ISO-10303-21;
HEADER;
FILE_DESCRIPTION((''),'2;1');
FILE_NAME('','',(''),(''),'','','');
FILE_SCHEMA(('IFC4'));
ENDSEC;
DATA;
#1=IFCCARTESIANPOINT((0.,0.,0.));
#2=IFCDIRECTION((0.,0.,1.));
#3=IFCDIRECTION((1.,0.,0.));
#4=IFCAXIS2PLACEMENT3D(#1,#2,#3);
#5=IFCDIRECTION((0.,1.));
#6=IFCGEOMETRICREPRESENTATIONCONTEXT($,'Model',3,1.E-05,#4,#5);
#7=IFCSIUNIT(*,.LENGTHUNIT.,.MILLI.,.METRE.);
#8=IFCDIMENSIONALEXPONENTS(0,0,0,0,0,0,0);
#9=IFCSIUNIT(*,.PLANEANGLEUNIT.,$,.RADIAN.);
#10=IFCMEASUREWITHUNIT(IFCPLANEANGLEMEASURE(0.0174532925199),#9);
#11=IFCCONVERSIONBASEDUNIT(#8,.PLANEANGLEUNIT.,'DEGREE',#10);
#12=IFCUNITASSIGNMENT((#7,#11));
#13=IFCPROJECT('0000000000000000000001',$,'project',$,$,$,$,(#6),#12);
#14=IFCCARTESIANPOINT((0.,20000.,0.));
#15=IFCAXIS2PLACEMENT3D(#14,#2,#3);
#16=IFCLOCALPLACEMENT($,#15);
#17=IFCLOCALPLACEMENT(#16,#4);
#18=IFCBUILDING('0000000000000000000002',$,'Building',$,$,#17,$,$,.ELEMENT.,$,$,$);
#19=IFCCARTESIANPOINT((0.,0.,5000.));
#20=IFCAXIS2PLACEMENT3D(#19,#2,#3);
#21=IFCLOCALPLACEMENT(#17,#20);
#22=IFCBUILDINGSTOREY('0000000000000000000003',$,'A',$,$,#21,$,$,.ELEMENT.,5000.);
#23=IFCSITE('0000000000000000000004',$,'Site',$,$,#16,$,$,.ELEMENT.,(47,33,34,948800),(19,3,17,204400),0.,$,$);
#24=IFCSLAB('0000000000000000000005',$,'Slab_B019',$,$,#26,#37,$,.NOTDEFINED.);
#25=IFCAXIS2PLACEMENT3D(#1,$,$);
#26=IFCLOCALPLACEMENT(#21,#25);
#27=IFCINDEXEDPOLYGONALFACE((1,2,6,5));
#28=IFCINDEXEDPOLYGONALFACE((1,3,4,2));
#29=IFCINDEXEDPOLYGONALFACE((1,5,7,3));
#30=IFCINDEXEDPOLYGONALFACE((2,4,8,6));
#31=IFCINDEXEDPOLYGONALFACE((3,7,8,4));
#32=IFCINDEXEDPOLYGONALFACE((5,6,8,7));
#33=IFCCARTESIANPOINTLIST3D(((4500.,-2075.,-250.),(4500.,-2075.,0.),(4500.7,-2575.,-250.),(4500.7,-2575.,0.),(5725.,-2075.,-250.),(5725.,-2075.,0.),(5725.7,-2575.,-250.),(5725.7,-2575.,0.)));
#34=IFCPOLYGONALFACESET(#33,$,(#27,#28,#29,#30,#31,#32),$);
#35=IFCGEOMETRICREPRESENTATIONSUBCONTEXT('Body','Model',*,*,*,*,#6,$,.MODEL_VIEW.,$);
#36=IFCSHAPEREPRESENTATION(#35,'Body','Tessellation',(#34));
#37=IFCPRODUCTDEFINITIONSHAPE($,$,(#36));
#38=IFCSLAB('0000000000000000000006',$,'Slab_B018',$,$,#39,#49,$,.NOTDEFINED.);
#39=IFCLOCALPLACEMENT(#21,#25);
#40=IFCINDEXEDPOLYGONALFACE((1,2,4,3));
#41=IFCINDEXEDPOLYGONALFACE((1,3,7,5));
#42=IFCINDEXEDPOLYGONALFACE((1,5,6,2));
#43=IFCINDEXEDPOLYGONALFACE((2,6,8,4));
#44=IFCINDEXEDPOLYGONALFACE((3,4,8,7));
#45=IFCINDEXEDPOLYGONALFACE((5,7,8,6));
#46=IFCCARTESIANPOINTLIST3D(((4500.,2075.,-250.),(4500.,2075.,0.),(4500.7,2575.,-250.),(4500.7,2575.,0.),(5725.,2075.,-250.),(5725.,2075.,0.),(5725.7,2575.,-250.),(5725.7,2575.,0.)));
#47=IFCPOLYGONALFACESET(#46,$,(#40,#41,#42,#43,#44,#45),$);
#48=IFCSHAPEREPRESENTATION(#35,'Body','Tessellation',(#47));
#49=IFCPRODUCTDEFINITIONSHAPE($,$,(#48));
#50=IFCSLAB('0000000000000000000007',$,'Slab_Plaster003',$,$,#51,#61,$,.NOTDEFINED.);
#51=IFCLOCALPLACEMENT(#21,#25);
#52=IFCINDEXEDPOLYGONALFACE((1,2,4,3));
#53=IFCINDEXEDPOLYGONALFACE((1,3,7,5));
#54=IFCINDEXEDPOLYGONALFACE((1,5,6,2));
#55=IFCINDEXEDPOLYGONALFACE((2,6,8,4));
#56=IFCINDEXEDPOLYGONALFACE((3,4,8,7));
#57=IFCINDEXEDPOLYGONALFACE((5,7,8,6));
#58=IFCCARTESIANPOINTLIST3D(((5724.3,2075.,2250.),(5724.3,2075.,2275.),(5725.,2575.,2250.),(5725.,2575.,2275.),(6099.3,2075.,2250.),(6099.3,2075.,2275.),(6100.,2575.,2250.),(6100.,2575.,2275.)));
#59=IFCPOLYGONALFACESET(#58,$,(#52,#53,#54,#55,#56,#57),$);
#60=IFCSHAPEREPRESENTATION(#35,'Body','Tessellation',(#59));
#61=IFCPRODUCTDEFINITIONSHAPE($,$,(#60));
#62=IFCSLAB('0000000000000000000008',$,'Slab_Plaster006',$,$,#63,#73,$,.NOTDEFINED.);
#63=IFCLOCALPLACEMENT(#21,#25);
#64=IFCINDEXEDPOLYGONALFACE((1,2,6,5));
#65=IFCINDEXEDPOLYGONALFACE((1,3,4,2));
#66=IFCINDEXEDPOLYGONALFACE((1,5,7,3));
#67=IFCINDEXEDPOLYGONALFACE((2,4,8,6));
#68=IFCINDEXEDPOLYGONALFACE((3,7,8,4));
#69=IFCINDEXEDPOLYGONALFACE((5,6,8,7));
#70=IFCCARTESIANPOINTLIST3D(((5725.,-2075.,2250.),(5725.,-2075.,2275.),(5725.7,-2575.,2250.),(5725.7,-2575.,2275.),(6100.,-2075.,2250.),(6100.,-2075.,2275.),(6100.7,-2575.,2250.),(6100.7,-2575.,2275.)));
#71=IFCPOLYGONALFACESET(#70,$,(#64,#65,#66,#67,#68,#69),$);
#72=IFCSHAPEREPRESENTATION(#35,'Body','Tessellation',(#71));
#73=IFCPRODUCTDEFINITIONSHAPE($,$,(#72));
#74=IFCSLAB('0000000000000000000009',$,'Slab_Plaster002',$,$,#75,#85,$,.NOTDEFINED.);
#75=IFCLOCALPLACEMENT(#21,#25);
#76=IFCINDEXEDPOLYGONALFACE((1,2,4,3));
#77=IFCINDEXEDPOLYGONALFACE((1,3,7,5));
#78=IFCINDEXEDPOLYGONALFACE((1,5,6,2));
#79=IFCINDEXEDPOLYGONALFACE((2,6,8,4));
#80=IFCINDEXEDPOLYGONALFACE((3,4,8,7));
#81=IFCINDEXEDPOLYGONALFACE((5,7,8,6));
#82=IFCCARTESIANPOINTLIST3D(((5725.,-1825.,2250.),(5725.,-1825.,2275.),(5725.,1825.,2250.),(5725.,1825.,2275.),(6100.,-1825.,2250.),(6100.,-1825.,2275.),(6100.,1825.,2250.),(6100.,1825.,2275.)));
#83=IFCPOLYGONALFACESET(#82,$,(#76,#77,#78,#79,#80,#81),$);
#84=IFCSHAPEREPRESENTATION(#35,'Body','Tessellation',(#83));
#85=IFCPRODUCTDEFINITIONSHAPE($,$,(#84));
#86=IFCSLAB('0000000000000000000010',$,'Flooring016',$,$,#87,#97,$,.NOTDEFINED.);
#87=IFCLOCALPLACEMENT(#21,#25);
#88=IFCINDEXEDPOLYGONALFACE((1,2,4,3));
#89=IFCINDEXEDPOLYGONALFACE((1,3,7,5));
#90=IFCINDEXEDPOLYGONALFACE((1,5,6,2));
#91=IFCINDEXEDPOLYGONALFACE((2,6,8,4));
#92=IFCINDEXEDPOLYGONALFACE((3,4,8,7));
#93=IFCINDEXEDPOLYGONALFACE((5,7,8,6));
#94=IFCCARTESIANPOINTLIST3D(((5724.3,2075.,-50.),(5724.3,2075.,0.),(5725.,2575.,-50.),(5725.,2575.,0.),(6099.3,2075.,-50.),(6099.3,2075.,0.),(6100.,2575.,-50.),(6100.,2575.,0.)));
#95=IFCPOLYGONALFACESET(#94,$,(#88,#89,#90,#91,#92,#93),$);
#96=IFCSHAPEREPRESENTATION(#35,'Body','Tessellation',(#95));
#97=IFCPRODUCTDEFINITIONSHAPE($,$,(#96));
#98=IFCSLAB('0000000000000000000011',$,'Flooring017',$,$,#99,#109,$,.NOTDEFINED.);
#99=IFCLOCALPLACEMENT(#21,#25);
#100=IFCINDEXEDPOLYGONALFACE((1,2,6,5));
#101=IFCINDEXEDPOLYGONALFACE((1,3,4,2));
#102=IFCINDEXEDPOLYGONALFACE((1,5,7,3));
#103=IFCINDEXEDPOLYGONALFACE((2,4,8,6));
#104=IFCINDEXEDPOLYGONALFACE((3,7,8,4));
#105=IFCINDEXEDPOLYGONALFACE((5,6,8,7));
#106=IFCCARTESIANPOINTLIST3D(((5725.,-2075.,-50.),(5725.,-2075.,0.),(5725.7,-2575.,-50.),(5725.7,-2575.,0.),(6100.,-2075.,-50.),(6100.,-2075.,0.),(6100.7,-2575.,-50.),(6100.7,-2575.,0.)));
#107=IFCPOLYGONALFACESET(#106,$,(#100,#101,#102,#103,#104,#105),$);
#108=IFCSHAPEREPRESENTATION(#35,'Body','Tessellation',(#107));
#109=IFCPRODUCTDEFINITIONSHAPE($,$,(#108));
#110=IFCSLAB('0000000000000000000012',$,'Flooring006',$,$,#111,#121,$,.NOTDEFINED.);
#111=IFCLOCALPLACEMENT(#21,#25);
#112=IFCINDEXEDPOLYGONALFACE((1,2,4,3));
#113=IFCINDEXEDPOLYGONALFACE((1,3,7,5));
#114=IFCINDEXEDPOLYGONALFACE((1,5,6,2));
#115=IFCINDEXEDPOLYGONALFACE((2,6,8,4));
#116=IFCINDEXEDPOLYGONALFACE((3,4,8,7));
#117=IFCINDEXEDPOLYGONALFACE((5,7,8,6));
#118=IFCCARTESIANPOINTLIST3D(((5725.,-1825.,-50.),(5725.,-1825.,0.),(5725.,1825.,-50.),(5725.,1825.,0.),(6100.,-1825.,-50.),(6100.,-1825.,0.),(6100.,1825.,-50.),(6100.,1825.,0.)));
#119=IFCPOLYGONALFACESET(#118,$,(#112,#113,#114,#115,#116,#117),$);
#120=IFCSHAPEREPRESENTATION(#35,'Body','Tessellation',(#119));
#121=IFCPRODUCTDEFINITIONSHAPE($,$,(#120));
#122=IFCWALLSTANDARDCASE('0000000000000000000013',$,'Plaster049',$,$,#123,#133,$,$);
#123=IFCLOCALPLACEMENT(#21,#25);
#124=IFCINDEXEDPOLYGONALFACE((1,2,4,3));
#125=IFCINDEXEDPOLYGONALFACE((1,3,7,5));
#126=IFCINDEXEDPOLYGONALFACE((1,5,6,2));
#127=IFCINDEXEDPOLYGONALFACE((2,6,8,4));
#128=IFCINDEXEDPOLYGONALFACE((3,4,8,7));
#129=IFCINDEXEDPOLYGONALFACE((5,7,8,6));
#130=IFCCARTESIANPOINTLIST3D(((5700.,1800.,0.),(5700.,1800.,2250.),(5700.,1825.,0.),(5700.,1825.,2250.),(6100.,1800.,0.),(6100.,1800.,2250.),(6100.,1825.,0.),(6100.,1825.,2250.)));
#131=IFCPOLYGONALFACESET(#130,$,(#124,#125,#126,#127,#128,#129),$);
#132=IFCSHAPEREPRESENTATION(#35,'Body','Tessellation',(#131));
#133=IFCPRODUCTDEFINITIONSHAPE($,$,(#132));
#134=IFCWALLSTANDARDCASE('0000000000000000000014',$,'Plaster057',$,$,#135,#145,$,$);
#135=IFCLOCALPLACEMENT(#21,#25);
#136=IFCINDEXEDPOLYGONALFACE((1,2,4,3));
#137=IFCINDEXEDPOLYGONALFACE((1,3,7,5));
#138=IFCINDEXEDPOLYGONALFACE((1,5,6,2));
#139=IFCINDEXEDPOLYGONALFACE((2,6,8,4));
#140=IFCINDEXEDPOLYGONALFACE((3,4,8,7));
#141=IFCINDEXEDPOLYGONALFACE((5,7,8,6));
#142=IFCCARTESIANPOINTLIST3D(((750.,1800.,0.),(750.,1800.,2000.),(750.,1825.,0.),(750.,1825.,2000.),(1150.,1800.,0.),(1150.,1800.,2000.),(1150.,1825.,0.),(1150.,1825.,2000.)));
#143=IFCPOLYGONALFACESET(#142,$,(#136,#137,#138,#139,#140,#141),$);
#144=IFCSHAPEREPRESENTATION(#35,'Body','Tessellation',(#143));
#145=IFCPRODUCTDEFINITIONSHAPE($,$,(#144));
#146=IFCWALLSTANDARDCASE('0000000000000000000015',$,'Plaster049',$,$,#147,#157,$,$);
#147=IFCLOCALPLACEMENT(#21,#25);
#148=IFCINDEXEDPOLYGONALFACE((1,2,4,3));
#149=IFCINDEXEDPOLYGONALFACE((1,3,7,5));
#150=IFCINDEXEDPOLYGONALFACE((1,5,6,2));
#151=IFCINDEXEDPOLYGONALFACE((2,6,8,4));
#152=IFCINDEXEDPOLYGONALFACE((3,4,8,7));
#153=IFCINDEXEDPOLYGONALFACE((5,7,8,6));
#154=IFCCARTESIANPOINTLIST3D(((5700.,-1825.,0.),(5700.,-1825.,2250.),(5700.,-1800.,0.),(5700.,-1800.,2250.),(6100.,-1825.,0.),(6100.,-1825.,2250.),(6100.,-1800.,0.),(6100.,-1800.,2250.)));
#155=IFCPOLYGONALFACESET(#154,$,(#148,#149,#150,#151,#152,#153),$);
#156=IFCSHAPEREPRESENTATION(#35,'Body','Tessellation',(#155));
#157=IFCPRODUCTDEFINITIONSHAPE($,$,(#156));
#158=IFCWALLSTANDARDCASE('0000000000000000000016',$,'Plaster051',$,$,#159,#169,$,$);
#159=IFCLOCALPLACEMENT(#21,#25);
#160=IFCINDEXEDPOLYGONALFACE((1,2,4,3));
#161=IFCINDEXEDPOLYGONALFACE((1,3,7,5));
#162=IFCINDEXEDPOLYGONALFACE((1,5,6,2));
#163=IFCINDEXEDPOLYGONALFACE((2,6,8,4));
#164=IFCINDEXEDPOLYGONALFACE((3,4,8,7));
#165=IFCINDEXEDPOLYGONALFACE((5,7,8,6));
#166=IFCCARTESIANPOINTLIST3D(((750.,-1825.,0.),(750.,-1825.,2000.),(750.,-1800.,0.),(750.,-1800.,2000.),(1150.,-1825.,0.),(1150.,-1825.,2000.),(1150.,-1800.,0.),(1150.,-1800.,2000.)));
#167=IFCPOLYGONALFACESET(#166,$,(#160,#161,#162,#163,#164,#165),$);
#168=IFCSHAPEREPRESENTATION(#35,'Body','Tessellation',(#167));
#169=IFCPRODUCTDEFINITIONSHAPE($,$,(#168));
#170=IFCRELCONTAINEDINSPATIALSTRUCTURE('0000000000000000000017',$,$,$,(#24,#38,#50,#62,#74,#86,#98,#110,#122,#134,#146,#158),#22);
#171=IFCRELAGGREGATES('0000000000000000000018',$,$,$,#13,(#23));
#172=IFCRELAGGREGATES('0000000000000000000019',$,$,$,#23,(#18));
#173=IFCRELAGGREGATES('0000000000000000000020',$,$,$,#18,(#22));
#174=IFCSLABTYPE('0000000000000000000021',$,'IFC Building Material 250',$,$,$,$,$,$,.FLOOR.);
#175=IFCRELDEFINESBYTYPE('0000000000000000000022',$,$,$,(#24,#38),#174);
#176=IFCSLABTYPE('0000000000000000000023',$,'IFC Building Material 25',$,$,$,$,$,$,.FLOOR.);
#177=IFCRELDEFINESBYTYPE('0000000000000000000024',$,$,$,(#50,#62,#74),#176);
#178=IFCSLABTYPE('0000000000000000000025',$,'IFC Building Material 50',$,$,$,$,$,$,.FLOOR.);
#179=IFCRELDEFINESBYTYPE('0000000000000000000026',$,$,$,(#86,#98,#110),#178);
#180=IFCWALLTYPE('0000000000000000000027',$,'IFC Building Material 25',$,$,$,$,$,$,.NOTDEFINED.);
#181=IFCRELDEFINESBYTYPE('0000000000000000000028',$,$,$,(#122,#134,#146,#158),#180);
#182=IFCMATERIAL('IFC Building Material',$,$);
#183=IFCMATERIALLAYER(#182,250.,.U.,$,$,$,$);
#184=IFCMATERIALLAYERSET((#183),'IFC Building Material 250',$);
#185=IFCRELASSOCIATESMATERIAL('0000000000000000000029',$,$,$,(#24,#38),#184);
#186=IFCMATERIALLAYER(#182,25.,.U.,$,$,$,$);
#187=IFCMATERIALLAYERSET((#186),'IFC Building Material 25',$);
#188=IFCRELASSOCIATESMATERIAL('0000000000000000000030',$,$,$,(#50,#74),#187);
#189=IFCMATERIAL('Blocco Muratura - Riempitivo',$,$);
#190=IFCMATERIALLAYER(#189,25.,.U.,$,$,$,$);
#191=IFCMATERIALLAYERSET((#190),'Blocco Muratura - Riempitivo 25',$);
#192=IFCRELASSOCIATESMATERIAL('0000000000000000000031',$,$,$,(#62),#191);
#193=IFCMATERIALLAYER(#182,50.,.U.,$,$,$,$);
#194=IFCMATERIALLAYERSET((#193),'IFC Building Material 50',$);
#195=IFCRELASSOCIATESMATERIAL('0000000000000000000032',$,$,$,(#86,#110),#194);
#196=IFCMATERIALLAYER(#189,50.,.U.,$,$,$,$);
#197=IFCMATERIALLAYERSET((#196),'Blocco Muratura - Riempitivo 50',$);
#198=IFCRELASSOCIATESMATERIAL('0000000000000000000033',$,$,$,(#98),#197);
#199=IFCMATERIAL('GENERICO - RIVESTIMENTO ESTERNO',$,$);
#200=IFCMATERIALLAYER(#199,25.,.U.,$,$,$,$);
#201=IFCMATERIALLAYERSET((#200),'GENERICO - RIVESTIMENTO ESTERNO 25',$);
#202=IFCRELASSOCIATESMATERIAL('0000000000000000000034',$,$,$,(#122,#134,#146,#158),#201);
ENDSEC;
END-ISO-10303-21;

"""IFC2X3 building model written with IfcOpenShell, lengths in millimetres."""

from ifc_helpers import new_model, entity, si_unit, converted_unit, direction, frame, origin_with_axes, place, context, subcontext, project, spatial, polyline, outline, extrude, material, layer, layer_set, layer_usage, type_object, element, save


model = new_model("IFC2X3")

# Units and contexts
model_context = context("Model", 3, precision=1e-05, world=origin_with_axes(), true_north=direction((0.0, 1.0)))
body_context = subcontext(model_context, "Body", "Model", "MODEL_VIEW")
ifc_project = project(units=[si_unit("LENGTHUNIT", "METRE", prefix="MILLI"), converted_unit("PLANEANGLEUNIT", "DEGREE", entity("IfcPlaneAngleMeasure", 0.0174532925199), si_unit("PLANEANGLEUNIT", "RADIAN"), dimensions=[0, 0, 0, 0, 0, 0, 0])], contexts=[model_context])

# Site, building, storey
site_placement = place(None, frame((0.0, 20000.0, 0.0), z_axis=(0.0, 0.0, 1.0), x_axis=(1.0, 0.0, 0.0)))
site = spatial("IfcSite", under=ifc_project, at=site_placement, Name="Site", CompositionType="ELEMENT", RefLatitude=(47, 33, 34, 948800), RefLongitude=(19, 3, 17, 204400), RefElevation=0.0)
building_placement = place(site_placement, origin_with_axes())
building = spatial("IfcBuilding", under=site, at=building_placement, Name="Building", CompositionType="ELEMENT")
storey_placement = place(building_placement, frame((0.0, 0.0, 5000.0), z_axis=(0.0, 0.0, 1.0), x_axis=(1.0, 0.0, 0.0)))
storey = spatial("IfcBuildingStorey", under=building, at=storey_placement, Name="A", CompositionType="ELEMENT", Elevation=5000.0)

# Shared definitions
ifc_material_1 = material(Name="GENERICO - RIVESTIMENTO ESTERNO")

# Slabs
ifc_material_2 = material(Name="IFC Building Material")
ifc_layer_1 = layer(ifc_material_2, 250.0, ventilated="UNKNOWN")
ifc_layer_set_1 = layer_set([ifc_layer_1], Name="IFC Building Material 250")
slab_type_1 = type_object("IfcSlabType", Name="IFC Building Material 250", PredefinedType="FLOOR")
ifc_layer_usage_1 = layer_usage(ifc_layer_set_1, "AXIS3", "NEGATIVE", 250.0)
slab_1_placement = place(storey_placement, frame((5725.0, -2075.0, 0.0), z_axis=(0.0, 0.0, 1.0), x_axis=(1.0, 0.0, 0.0)))
element("IfcSlab", 1, at=slab_1_placement, inside=storey, type_object=slab_type_1, material=ifc_layer_usage_1, Name="Slab_B019", PredefinedType="NOTDEFINED", context=body_context, shape_type="SweptSolid", body=[
    extrude(outline(polyline([(0.0, 0.0), (-1225.0, 0.0), (-1224.3, -500.0), (0.7, -500.0), (0.0, 0.0)])), frame((0.0, 0.0, -250.0), z_axis=(0.0, 0.0, 1.0), x_axis=(1.0, 0.0, 0.0)), (0.0, 0.0, 1.0), 250.0),
])
ifc_layer_usage_2 = layer_usage(ifc_layer_set_1, "AXIS3", "NEGATIVE", 250.0)
slab_2_placement = place(storey_placement, frame((4500.7, 2575.0, 0.0), z_axis=(0.0, 0.0, 1.0), x_axis=(1.0, 0.0, 0.0)))
element("IfcSlab", 2, at=slab_2_placement, inside=storey, type_object=slab_type_1, material=ifc_layer_usage_2, Name="Slab_B018", PredefinedType="NOTDEFINED", context=body_context, shape_type="SweptSolid", body=[
    extrude(outline(polyline([(0.0, 0.0), (-0.7, -500.0), (1224.3, -500.0), (1225.0, 0.0), (0.0, 0.0)])), frame((0.0, 0.0, -250.0), z_axis=(0.0, 0.0, 1.0), x_axis=(1.0, 0.0, 0.0)), (0.0, 0.0, 1.0), 250.0),
])
ifc_layer_2 = layer(ifc_material_2, 25.0, ventilated="UNKNOWN")
ifc_layer_set_2 = layer_set([ifc_layer_2], Name="IFC Building Material 25")
ifc_layer_usage_3 = layer_usage(ifc_layer_set_2, "AXIS3", "NEGATIVE", 25.0)
slab_type_2 = type_object("IfcSlabType", Name="IFC Building Material 25", PredefinedType="FLOOR")
slab_3_placement = place(storey_placement, frame((5724.3, 2075.0, 2275.0), z_axis=(0.0, 0.0, 1.0), x_axis=(1.0, 0.0, 0.0)))
element("IfcSlab", 3, at=slab_3_placement, inside=storey, type_object=slab_type_2, material=ifc_layer_usage_3, Name="Slab_Plaster003", PredefinedType="NOTDEFINED", context=body_context, shape_type="SweptSolid", body=[
    extrude(outline(polyline([(0.0, 0.0), (375.0, 0.0), (375.7, 500.0), (0.7, 500.0), (0.0, 0.0)])), frame((0.0, 0.0, -25.0), z_axis=(0.0, 0.0, 1.0), x_axis=(1.0, 0.0, 0.0)), (0.0, 0.0, 1.0), 25.0),
])
ifc_material_3 = material(Name="Blocco Muratura - Riempitivo")
ifc_layer_3 = layer(ifc_material_3, 25.0, ventilated="UNKNOWN")
ifc_layer_set_3 = layer_set([ifc_layer_3], Name="Blocco Muratura - Riempitivo 25")
ifc_layer_usage_4 = layer_usage(ifc_layer_set_3, "AXIS3", "NEGATIVE", 25.0)
slab_4_placement = place(storey_placement, frame((5725.0, -2075.0, 2275.0), z_axis=(0.0, 0.0, 1.0), x_axis=(1.0, 0.0, 0.0)))
element("IfcSlab", 4, at=slab_4_placement, inside=storey, type_object=slab_type_2, material=ifc_layer_usage_4, Name="Slab_Plaster006", PredefinedType="NOTDEFINED", context=body_context, shape_type="SweptSolid", body=[
    extrude(outline(polyline([(0.0, 0.0), (0.7, -500.0), (375.7, -500.0), (375.0, 0.0), (0.0, 0.0)])), frame((0.0, 0.0, -25.0), z_axis=(0.0, 0.0, 1.0), x_axis=(1.0, 0.0, 0.0)), (0.0, 0.0, 1.0), 25.0),
])
ifc_layer_usage_5 = layer_usage(ifc_layer_set_2, "AXIS3", "NEGATIVE", 25.0)
slab_5_placement = place(storey_placement, frame((5725.0, 1825.0, 2275.0), z_axis=(0.0, 0.0, 1.0), x_axis=(1.0, 0.0, 0.0)))
element("IfcSlab", 5, at=slab_5_placement, inside=storey, type_object=slab_type_2, material=ifc_layer_usage_5, Name="Slab_Plaster002", PredefinedType="NOTDEFINED", context=body_context, shape_type="SweptSolid", body=[
    extrude(outline(polyline([(0.0, 0.0), (0.0, -3650.0), (375.0, -3650.0), (375.0, 0.0), (0.0, 0.0)])), frame((0.0, 0.0, -25.0), z_axis=(0.0, 0.0, 1.0), x_axis=(1.0, 0.0, 0.0)), (0.0, 0.0, 1.0), 25.0),
])
ifc_layer_4 = layer(ifc_material_2, 50.0, ventilated="UNKNOWN")
ifc_layer_set_4 = layer_set([ifc_layer_4], Name="IFC Building Material 50")
ifc_layer_usage_6 = layer_usage(ifc_layer_set_4, "AXIS3", "NEGATIVE", 50.0)
slab_type_3 = type_object("IfcSlabType", Name="IFC Building Material 50", PredefinedType="FLOOR")
slab_6_placement = place(storey_placement, frame((5724.3, 2075.0, 0.0), z_axis=(0.0, 0.0, 1.0), x_axis=(1.0, 0.0, 0.0)))
element("IfcSlab", 6, at=slab_6_placement, inside=storey, type_object=slab_type_3, material=ifc_layer_usage_6, Name="Flooring016", PredefinedType="NOTDEFINED", context=body_context, shape_type="SweptSolid", body=[
    extrude(outline(polyline([(0.0, 0.0), (375.0, 0.0), (375.7, 500.0), (0.7, 500.0), (0.0, 0.0)])), frame((0.0, 0.0, -50.0), z_axis=(0.0, 0.0, 1.0), x_axis=(1.0, 0.0, 0.0)), (0.0, 0.0, 1.0), 50.0),
])
ifc_layer_5 = layer(ifc_material_3, 50.0, ventilated="UNKNOWN")
ifc_layer_set_5 = layer_set([ifc_layer_5], Name="Blocco Muratura - Riempitivo 50")
ifc_layer_usage_7 = layer_usage(ifc_layer_set_5, "AXIS3", "NEGATIVE", 50.0)
slab_7_placement = place(storey_placement, frame((5725.0, -2075.0, 0.0), z_axis=(0.0, 0.0, 1.0), x_axis=(1.0, 0.0, 0.0)))
element("IfcSlab", 7, at=slab_7_placement, inside=storey, type_object=slab_type_3, material=ifc_layer_usage_7, Name="Flooring017", PredefinedType="NOTDEFINED", context=body_context, shape_type="SweptSolid", body=[
    extrude(outline(polyline([(0.0, 0.0), (0.7, -500.0), (375.7, -500.0), (375.0, 0.0), (0.0, 0.0)])), frame((0.0, 0.0, -50.0), z_axis=(0.0, 0.0, 1.0), x_axis=(1.0, 0.0, 0.0)), (0.0, 0.0, 1.0), 50.0),
])
ifc_layer_usage_8 = layer_usage(ifc_layer_set_4, "AXIS3", "NEGATIVE", 50.0)
slab_8_placement = place(storey_placement, frame((5725.0, 1825.0, 0.0), z_axis=(0.0, 0.0, 1.0), x_axis=(1.0, 0.0, 0.0)))
element("IfcSlab", 8, at=slab_8_placement, inside=storey, type_object=slab_type_3, material=ifc_layer_usage_8, Name="Flooring006", PredefinedType="NOTDEFINED", context=body_context, shape_type="SweptSolid", body=[
    extrude(outline(polyline([(0.0, 0.0), (0.0, -3650.0), (375.0, -3650.0), (375.0, 0.0), (0.0, 0.0)])), frame((0.0, 0.0, -50.0), z_axis=(0.0, 0.0, 1.0), x_axis=(1.0, 0.0, 0.0)), (0.0, 0.0, 1.0), 50.0),
])

# Walls
ifc_layer_6 = layer(ifc_material_1, 25.0, ventilated="UNKNOWN")
ifc_layer_set_6 = layer_set([ifc_layer_6], Name="GENERICO - RIVESTIMENTO ESTERNO 25")
ifc_layer_usage_9 = layer_usage(ifc_layer_set_6, "AXIS2", "POSITIVE", 0.0)
wall_type_1 = type_object("IfcWallType", Name="IFC Building Material 25", PredefinedType="NOTDEFINED")
wall_1_placement = place(storey_placement, frame((5700.0, 1800.0, 0.0), z_axis=(0.0, 0.0, 1.0), x_axis=(1.0, 0.0, 0.0)))
element("IfcWallStandardCase", 9, at=wall_1_placement, inside=storey, type_object=wall_type_1, material=ifc_layer_usage_9, Name="Plaster049", context=body_context, shape_type="SweptSolid", body=[
    extrude(outline(polyline([(0.0, 0.0), (400.0, 0.0), (400.0, 25.0), (0.0, 25.0), (0.0, 0.0)])), origin_with_axes(), (0.0, 0.0, 1.0), 2250.0),
])
ifc_layer_usage_10 = layer_usage(ifc_layer_set_6, "AXIS2", "POSITIVE", 0.0)
wall_2_placement = place(storey_placement, frame((750.0, 1800.0, 0.0), z_axis=(0.0, 0.0, 1.0), x_axis=(1.0, 0.0, 0.0)))
element("IfcWallStandardCase", 10, at=wall_2_placement, inside=storey, type_object=wall_type_1, material=ifc_layer_usage_10, Name="Plaster057", context=body_context, shape_type="SweptSolid", body=[
    extrude(outline(polyline([(0.0, 0.0), (400.0, 0.0), (400.0, 25.0), (0.0, 25.0), (0.0, 0.0)])), origin_with_axes(), (0.0, 0.0, 1.0), 2000.0),
])
ifc_layer_usage_11 = layer_usage(ifc_layer_set_6, "AXIS2", "POSITIVE", -25.0)
wall_3_placement = place(storey_placement, frame((5700.0, -1800.0, 0.0), z_axis=(0.0, 0.0, 1.0), x_axis=(1.0, 0.0, 0.0)))
element("IfcWallStandardCase", 11, at=wall_3_placement, inside=storey, type_object=wall_type_1, material=ifc_layer_usage_11, Name="Plaster049", context=body_context, shape_type="SweptSolid", body=[
    extrude(outline(polyline([(0.0, -25.0), (400.0, -25.0), (400.0, 0.0), (0.0, 0.0), (0.0, -25.0)])), origin_with_axes(), (0.0, 0.0, 1.0), 2250.0),
])
ifc_layer_usage_12 = layer_usage(ifc_layer_set_6, "AXIS2", "POSITIVE", -25.0)
wall_4_placement = place(storey_placement, frame((750.0, -1800.0, 0.0), z_axis=(0.0, 0.0, 1.0), x_axis=(1.0, 0.0, 0.0)))
element("IfcWallStandardCase", 12, at=wall_4_placement, inside=storey, type_object=wall_type_1, material=ifc_layer_usage_12, Name="Plaster051", context=body_context, shape_type="SweptSolid", body=[
    extrude(outline(polyline([(0.0, -25.0), (400.0, -25.0), (400.0, 0.0), (0.0, 0.0), (0.0, -25.0)])), origin_with_axes(), (0.0, 0.0, 1.0), 2000.0),
])

save(model, "model.ifc")
